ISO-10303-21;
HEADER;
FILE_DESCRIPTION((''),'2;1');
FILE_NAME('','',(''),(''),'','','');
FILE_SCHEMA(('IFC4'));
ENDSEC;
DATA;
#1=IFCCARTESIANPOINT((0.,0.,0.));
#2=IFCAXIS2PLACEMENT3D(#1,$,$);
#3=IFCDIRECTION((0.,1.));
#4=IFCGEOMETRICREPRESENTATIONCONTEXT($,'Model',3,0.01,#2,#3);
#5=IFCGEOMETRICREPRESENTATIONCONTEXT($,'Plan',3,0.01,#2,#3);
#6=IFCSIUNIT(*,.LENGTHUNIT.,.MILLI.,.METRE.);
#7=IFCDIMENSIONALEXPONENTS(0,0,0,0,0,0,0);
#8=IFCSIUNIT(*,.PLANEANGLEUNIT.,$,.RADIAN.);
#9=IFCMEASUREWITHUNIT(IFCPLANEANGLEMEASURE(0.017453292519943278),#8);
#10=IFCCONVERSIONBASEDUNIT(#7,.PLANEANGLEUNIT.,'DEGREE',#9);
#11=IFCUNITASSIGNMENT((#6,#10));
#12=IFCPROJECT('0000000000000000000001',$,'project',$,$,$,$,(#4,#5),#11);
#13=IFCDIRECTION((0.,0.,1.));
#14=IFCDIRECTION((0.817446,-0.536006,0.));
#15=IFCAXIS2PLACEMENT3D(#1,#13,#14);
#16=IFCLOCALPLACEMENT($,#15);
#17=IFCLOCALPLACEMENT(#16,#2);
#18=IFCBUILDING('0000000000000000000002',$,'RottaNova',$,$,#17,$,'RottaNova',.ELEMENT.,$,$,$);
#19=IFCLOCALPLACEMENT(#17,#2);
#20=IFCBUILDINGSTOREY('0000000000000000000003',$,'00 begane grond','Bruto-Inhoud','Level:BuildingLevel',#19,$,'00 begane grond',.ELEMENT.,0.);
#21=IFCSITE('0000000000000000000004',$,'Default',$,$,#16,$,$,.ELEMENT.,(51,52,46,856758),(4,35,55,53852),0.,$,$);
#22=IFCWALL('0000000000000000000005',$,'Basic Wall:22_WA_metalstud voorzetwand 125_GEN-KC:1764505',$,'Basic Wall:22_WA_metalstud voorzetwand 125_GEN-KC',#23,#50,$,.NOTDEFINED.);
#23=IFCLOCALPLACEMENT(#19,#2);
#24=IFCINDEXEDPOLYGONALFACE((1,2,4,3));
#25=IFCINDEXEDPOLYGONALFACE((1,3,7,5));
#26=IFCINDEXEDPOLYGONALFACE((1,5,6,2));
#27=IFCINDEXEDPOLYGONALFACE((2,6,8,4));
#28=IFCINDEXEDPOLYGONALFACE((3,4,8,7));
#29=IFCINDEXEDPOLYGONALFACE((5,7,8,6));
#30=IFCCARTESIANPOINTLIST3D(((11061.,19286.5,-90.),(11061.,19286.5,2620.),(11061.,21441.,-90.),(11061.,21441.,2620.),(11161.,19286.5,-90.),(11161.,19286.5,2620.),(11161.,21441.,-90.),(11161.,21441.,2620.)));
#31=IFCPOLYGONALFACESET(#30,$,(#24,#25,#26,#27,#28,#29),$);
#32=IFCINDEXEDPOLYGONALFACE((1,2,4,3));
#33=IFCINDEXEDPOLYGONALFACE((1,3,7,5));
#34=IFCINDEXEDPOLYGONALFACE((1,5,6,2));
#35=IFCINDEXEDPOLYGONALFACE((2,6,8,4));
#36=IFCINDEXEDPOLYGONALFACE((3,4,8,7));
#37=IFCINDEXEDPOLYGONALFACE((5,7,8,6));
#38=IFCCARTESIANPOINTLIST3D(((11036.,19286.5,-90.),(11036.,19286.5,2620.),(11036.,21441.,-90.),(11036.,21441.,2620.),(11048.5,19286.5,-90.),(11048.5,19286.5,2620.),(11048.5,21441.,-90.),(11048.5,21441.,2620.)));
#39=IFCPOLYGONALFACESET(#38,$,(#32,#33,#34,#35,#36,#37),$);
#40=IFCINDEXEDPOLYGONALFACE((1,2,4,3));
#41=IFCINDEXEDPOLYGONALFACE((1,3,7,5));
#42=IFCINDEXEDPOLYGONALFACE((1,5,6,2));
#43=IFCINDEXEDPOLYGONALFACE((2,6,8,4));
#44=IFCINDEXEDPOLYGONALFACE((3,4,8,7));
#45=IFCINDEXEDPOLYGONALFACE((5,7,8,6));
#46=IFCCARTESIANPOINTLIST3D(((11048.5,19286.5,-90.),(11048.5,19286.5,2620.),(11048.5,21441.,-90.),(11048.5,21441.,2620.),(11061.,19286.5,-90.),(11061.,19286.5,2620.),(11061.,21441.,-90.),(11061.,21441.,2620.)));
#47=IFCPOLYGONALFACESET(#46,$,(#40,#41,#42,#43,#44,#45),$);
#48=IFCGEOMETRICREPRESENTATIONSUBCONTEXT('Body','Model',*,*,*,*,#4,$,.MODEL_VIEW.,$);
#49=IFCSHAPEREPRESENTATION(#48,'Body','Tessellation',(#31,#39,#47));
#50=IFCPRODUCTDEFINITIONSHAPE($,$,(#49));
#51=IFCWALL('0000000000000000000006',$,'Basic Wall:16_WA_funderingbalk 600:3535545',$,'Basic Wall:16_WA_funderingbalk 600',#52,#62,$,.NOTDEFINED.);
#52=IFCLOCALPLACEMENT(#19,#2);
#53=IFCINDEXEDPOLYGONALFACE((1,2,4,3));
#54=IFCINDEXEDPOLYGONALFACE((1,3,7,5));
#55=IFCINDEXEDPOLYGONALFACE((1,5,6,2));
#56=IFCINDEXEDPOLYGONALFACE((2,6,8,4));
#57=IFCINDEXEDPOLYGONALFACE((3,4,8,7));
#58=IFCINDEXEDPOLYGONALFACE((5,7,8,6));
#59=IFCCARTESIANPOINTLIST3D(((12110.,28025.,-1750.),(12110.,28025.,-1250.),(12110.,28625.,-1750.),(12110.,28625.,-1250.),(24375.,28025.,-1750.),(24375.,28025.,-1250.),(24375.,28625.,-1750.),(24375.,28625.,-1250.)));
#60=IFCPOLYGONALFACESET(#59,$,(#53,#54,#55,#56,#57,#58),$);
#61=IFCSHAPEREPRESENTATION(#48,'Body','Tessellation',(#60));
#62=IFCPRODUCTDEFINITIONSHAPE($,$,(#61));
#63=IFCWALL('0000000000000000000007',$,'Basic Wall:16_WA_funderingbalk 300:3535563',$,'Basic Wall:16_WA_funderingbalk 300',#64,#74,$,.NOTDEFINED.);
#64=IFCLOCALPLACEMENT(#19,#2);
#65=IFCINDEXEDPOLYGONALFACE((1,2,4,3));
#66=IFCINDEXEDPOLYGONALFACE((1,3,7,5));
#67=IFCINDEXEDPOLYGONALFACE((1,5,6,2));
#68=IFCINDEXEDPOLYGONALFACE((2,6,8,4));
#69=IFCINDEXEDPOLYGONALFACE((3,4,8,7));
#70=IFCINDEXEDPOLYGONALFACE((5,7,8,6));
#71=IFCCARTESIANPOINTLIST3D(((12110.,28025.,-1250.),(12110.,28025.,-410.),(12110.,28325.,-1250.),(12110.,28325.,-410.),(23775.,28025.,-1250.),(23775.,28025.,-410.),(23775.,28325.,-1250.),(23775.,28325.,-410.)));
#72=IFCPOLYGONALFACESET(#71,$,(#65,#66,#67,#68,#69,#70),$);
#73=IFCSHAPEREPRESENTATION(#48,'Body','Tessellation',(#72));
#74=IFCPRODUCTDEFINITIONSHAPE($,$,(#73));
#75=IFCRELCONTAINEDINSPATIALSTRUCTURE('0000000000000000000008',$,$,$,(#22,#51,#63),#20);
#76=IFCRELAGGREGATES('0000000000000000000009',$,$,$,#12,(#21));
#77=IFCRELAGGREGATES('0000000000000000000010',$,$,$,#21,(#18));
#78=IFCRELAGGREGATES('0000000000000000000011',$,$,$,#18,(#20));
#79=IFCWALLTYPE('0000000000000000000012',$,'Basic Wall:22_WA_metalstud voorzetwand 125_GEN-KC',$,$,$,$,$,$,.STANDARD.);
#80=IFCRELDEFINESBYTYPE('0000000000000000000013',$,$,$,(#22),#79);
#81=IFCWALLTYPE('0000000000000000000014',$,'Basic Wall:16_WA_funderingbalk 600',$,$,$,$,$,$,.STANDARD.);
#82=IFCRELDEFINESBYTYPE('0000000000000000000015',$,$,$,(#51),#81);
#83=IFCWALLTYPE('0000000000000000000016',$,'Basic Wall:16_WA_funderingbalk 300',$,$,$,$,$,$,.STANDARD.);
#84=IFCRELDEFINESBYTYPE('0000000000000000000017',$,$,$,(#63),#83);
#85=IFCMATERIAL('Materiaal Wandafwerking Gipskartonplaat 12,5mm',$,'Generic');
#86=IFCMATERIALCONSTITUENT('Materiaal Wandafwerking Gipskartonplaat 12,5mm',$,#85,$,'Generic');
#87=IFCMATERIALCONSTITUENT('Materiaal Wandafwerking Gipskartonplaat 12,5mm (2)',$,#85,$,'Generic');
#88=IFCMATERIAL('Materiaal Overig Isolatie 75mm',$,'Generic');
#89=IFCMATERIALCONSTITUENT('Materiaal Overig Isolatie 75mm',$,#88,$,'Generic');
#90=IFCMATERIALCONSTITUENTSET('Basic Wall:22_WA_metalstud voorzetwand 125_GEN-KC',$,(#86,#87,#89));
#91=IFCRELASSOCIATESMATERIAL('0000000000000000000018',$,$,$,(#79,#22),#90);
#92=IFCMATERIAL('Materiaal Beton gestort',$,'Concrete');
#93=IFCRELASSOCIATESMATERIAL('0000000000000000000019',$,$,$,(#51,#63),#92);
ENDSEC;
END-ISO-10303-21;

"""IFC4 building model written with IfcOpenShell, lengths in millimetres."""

from ifc_helpers import new_model, entity, si_unit, converted_unit, direction, frame, origin, place, context, subcontext, project, spatial, indexed_curve, outline, extrude, material, constituent, constituent_set, type_object, element, save


model = new_model("IFC4")

# Units and contexts
model_context = context("Model", 3, precision=0.01, world=origin(), true_north=direction((0.0, 1.0)))
plan_context = context("Plan", 3, precision=0.01, world=origin(), true_north=direction((0.0, 1.0)))
body_context = subcontext(model_context, "Body", "Model", "MODEL_VIEW")
ifc_project = project(units=[si_unit("LENGTHUNIT", "METRE", prefix="MILLI"), converted_unit("PLANEANGLEUNIT", "DEGREE", entity("IfcPlaneAngleMeasure", 0.017453292519943278), si_unit("PLANEANGLEUNIT", "RADIAN"), dimensions=[0, 0, 0, 0, 0, 0, 0])], contexts=[model_context, plan_context])

# Site, building, storey
site_placement = place(None, frame((0.0, 0.0, 0.0), z_axis=(0.0, 0.0, 1.0), x_axis=(0.817446, -0.536006, 0.0)))
site = spatial("IfcSite", under=ifc_project, at=site_placement, Name="Default", CompositionType="ELEMENT", RefLatitude=(51, 52, 46, 856758), RefLongitude=(4, 35, 55, 53852), RefElevation=0.0)
building_placement = place(site_placement, origin())
building = spatial("IfcBuilding", under=site, at=building_placement, Name="RottaNova", LongName="RottaNova", CompositionType="ELEMENT")
storey_placement = place(building_placement, origin())
storey = spatial("IfcBuildingStorey", under=building, at=storey_placement, Name="00 begane grond", Description="Bruto-Inhoud", ObjectType="Level:BuildingLevel", LongName="00 begane grond", CompositionType="ELEMENT", Elevation=0.0)

# Walls
ifc_material_1 = material(Name="Materiaal Wandafwerking Gipskartonplaat 12,5mm", Category="Generic")
ifc_constituent_1 = constituent(ifc_material_1, Name="Materiaal Wandafwerking Gipskartonplaat 12,5mm", Category="Generic")
ifc_constituent_2 = constituent(ifc_material_1, Name="Materiaal Wandafwerking Gipskartonplaat 12,5mm (2)", Category="Generic")
ifc_material_2 = material(Name="Materiaal Overig Isolatie 75mm", Category="Generic")
ifc_constituent_3 = constituent(ifc_material_2, Name="Materiaal Overig Isolatie 75mm", Category="Generic")
ifc_constituent_set = constituent_set(constituents=[ifc_constituent_1, ifc_constituent_2, ifc_constituent_3], Name="Basic Wall:22_WA_metalstud voorzetwand 125_GEN-KC")
wall_type_1 = type_object("IfcWallType", Name="Basic Wall:22_WA_metalstud voorzetwand 125_GEN-KC", PredefinedType="STANDARD", material=ifc_constituent_set)
wall_1_placement = place(storey_placement, frame((11098.5, 21441.0, -90.0), z_axis=(0.0, 0.0, 1.0), x_axis=(0.0, -1.0, 0.0)))
element("IfcWall", 1, at=wall_1_placement, inside=storey, type_object=wall_type_1, material=ifc_constituent_set, Name="Basic Wall:22_WA_metalstud voorzetwand 125_GEN-KC:1764505", ObjectType="Basic Wall:22_WA_metalstud voorzetwand 125_GEN-KC", PredefinedType="NOTDEFINED", context=body_context, shape_type="SweptSolid", body=[
    extrude(outline(indexed_curve([(-50.0, -1077.2), (50.0, -1077.2), (50.0, 1077.2), (-50.0, 1077.2), (-50.0, -1077.2)], self_intersect=False)), frame((1077.2, 12.5, 0.0), z_axis=(0.0, 0.0, 1.0), x_axis=(0.0, -1.0, 0.0)), (0.0, 0.0, 1.0), 2710.0),
    extrude(outline(indexed_curve([(-6.3, -1077.2), (6.2, -1077.2), (6.3, 1077.2), (-6.2, 1077.2), (-6.3, -1077.2)], self_intersect=False)), frame((1077.2, -56.2, 0.0), z_axis=(0.0, 0.0, 1.0), x_axis=(0.0, 1.0, 0.0)), (0.0, 0.0, 1.0), 2710.0),
    extrude(outline(indexed_curve([(-1077.2, -6.2), (1077.2, -6.3), (1077.2, 6.2), (-1077.2, 6.3), (-1077.2, -6.2)], self_intersect=False)), frame((1077.2, -43.8, 0.0)), (0.0, 0.0, 1.0), 2710.0),
])
ifc_material_3 = material(Name="Materiaal Beton gestort", Category="Concrete")
wall_type_2 = type_object("IfcWallType", Name="Basic Wall:16_WA_funderingbalk 600", PredefinedType="STANDARD")
wall_2_placement = place(storey_placement, frame((12110.0, 28325.0, -1750.0)))
element("IfcWall", 2, at=wall_2_placement, inside=storey, type_object=wall_type_2, material=ifc_material_3, Name="Basic Wall:16_WA_funderingbalk 600:3535545", ObjectType="Basic Wall:16_WA_funderingbalk 600", PredefinedType="NOTDEFINED", context=body_context, shape_type="SweptSolid", body=[
    extrude(outline(indexed_curve([(12265.0, 300.0), (0.0, 300.0), (0.0, -300.0), (12265.0, -300.0), (12265.0, 300.0)], self_intersect=False)), origin(), (0.0, 0.0, 1.0), 500.0),
])
wall_type_3 = type_object("IfcWallType", Name="Basic Wall:16_WA_funderingbalk 300", PredefinedType="STANDARD")
wall_3_placement = place(storey_placement, frame((12110.0, 28175.0, -1250.0)))
element("IfcWall", 3, at=wall_3_placement, inside=storey, type_object=wall_type_3, material=ifc_material_3, Name="Basic Wall:16_WA_funderingbalk 300:3535563", ObjectType="Basic Wall:16_WA_funderingbalk 300", PredefinedType="NOTDEFINED", context=body_context, shape_type="SweptSolid", body=[
    extrude(outline(indexed_curve([(11665.0, 150.0), (0.0, 150.0), (0.0, -150.0), (11665.0, -150.0), (11665.0, 150.0)], self_intersect=False)), origin(), (0.0, 0.0, 1.0), 840.0),
])

save(model, "model.ifc")
